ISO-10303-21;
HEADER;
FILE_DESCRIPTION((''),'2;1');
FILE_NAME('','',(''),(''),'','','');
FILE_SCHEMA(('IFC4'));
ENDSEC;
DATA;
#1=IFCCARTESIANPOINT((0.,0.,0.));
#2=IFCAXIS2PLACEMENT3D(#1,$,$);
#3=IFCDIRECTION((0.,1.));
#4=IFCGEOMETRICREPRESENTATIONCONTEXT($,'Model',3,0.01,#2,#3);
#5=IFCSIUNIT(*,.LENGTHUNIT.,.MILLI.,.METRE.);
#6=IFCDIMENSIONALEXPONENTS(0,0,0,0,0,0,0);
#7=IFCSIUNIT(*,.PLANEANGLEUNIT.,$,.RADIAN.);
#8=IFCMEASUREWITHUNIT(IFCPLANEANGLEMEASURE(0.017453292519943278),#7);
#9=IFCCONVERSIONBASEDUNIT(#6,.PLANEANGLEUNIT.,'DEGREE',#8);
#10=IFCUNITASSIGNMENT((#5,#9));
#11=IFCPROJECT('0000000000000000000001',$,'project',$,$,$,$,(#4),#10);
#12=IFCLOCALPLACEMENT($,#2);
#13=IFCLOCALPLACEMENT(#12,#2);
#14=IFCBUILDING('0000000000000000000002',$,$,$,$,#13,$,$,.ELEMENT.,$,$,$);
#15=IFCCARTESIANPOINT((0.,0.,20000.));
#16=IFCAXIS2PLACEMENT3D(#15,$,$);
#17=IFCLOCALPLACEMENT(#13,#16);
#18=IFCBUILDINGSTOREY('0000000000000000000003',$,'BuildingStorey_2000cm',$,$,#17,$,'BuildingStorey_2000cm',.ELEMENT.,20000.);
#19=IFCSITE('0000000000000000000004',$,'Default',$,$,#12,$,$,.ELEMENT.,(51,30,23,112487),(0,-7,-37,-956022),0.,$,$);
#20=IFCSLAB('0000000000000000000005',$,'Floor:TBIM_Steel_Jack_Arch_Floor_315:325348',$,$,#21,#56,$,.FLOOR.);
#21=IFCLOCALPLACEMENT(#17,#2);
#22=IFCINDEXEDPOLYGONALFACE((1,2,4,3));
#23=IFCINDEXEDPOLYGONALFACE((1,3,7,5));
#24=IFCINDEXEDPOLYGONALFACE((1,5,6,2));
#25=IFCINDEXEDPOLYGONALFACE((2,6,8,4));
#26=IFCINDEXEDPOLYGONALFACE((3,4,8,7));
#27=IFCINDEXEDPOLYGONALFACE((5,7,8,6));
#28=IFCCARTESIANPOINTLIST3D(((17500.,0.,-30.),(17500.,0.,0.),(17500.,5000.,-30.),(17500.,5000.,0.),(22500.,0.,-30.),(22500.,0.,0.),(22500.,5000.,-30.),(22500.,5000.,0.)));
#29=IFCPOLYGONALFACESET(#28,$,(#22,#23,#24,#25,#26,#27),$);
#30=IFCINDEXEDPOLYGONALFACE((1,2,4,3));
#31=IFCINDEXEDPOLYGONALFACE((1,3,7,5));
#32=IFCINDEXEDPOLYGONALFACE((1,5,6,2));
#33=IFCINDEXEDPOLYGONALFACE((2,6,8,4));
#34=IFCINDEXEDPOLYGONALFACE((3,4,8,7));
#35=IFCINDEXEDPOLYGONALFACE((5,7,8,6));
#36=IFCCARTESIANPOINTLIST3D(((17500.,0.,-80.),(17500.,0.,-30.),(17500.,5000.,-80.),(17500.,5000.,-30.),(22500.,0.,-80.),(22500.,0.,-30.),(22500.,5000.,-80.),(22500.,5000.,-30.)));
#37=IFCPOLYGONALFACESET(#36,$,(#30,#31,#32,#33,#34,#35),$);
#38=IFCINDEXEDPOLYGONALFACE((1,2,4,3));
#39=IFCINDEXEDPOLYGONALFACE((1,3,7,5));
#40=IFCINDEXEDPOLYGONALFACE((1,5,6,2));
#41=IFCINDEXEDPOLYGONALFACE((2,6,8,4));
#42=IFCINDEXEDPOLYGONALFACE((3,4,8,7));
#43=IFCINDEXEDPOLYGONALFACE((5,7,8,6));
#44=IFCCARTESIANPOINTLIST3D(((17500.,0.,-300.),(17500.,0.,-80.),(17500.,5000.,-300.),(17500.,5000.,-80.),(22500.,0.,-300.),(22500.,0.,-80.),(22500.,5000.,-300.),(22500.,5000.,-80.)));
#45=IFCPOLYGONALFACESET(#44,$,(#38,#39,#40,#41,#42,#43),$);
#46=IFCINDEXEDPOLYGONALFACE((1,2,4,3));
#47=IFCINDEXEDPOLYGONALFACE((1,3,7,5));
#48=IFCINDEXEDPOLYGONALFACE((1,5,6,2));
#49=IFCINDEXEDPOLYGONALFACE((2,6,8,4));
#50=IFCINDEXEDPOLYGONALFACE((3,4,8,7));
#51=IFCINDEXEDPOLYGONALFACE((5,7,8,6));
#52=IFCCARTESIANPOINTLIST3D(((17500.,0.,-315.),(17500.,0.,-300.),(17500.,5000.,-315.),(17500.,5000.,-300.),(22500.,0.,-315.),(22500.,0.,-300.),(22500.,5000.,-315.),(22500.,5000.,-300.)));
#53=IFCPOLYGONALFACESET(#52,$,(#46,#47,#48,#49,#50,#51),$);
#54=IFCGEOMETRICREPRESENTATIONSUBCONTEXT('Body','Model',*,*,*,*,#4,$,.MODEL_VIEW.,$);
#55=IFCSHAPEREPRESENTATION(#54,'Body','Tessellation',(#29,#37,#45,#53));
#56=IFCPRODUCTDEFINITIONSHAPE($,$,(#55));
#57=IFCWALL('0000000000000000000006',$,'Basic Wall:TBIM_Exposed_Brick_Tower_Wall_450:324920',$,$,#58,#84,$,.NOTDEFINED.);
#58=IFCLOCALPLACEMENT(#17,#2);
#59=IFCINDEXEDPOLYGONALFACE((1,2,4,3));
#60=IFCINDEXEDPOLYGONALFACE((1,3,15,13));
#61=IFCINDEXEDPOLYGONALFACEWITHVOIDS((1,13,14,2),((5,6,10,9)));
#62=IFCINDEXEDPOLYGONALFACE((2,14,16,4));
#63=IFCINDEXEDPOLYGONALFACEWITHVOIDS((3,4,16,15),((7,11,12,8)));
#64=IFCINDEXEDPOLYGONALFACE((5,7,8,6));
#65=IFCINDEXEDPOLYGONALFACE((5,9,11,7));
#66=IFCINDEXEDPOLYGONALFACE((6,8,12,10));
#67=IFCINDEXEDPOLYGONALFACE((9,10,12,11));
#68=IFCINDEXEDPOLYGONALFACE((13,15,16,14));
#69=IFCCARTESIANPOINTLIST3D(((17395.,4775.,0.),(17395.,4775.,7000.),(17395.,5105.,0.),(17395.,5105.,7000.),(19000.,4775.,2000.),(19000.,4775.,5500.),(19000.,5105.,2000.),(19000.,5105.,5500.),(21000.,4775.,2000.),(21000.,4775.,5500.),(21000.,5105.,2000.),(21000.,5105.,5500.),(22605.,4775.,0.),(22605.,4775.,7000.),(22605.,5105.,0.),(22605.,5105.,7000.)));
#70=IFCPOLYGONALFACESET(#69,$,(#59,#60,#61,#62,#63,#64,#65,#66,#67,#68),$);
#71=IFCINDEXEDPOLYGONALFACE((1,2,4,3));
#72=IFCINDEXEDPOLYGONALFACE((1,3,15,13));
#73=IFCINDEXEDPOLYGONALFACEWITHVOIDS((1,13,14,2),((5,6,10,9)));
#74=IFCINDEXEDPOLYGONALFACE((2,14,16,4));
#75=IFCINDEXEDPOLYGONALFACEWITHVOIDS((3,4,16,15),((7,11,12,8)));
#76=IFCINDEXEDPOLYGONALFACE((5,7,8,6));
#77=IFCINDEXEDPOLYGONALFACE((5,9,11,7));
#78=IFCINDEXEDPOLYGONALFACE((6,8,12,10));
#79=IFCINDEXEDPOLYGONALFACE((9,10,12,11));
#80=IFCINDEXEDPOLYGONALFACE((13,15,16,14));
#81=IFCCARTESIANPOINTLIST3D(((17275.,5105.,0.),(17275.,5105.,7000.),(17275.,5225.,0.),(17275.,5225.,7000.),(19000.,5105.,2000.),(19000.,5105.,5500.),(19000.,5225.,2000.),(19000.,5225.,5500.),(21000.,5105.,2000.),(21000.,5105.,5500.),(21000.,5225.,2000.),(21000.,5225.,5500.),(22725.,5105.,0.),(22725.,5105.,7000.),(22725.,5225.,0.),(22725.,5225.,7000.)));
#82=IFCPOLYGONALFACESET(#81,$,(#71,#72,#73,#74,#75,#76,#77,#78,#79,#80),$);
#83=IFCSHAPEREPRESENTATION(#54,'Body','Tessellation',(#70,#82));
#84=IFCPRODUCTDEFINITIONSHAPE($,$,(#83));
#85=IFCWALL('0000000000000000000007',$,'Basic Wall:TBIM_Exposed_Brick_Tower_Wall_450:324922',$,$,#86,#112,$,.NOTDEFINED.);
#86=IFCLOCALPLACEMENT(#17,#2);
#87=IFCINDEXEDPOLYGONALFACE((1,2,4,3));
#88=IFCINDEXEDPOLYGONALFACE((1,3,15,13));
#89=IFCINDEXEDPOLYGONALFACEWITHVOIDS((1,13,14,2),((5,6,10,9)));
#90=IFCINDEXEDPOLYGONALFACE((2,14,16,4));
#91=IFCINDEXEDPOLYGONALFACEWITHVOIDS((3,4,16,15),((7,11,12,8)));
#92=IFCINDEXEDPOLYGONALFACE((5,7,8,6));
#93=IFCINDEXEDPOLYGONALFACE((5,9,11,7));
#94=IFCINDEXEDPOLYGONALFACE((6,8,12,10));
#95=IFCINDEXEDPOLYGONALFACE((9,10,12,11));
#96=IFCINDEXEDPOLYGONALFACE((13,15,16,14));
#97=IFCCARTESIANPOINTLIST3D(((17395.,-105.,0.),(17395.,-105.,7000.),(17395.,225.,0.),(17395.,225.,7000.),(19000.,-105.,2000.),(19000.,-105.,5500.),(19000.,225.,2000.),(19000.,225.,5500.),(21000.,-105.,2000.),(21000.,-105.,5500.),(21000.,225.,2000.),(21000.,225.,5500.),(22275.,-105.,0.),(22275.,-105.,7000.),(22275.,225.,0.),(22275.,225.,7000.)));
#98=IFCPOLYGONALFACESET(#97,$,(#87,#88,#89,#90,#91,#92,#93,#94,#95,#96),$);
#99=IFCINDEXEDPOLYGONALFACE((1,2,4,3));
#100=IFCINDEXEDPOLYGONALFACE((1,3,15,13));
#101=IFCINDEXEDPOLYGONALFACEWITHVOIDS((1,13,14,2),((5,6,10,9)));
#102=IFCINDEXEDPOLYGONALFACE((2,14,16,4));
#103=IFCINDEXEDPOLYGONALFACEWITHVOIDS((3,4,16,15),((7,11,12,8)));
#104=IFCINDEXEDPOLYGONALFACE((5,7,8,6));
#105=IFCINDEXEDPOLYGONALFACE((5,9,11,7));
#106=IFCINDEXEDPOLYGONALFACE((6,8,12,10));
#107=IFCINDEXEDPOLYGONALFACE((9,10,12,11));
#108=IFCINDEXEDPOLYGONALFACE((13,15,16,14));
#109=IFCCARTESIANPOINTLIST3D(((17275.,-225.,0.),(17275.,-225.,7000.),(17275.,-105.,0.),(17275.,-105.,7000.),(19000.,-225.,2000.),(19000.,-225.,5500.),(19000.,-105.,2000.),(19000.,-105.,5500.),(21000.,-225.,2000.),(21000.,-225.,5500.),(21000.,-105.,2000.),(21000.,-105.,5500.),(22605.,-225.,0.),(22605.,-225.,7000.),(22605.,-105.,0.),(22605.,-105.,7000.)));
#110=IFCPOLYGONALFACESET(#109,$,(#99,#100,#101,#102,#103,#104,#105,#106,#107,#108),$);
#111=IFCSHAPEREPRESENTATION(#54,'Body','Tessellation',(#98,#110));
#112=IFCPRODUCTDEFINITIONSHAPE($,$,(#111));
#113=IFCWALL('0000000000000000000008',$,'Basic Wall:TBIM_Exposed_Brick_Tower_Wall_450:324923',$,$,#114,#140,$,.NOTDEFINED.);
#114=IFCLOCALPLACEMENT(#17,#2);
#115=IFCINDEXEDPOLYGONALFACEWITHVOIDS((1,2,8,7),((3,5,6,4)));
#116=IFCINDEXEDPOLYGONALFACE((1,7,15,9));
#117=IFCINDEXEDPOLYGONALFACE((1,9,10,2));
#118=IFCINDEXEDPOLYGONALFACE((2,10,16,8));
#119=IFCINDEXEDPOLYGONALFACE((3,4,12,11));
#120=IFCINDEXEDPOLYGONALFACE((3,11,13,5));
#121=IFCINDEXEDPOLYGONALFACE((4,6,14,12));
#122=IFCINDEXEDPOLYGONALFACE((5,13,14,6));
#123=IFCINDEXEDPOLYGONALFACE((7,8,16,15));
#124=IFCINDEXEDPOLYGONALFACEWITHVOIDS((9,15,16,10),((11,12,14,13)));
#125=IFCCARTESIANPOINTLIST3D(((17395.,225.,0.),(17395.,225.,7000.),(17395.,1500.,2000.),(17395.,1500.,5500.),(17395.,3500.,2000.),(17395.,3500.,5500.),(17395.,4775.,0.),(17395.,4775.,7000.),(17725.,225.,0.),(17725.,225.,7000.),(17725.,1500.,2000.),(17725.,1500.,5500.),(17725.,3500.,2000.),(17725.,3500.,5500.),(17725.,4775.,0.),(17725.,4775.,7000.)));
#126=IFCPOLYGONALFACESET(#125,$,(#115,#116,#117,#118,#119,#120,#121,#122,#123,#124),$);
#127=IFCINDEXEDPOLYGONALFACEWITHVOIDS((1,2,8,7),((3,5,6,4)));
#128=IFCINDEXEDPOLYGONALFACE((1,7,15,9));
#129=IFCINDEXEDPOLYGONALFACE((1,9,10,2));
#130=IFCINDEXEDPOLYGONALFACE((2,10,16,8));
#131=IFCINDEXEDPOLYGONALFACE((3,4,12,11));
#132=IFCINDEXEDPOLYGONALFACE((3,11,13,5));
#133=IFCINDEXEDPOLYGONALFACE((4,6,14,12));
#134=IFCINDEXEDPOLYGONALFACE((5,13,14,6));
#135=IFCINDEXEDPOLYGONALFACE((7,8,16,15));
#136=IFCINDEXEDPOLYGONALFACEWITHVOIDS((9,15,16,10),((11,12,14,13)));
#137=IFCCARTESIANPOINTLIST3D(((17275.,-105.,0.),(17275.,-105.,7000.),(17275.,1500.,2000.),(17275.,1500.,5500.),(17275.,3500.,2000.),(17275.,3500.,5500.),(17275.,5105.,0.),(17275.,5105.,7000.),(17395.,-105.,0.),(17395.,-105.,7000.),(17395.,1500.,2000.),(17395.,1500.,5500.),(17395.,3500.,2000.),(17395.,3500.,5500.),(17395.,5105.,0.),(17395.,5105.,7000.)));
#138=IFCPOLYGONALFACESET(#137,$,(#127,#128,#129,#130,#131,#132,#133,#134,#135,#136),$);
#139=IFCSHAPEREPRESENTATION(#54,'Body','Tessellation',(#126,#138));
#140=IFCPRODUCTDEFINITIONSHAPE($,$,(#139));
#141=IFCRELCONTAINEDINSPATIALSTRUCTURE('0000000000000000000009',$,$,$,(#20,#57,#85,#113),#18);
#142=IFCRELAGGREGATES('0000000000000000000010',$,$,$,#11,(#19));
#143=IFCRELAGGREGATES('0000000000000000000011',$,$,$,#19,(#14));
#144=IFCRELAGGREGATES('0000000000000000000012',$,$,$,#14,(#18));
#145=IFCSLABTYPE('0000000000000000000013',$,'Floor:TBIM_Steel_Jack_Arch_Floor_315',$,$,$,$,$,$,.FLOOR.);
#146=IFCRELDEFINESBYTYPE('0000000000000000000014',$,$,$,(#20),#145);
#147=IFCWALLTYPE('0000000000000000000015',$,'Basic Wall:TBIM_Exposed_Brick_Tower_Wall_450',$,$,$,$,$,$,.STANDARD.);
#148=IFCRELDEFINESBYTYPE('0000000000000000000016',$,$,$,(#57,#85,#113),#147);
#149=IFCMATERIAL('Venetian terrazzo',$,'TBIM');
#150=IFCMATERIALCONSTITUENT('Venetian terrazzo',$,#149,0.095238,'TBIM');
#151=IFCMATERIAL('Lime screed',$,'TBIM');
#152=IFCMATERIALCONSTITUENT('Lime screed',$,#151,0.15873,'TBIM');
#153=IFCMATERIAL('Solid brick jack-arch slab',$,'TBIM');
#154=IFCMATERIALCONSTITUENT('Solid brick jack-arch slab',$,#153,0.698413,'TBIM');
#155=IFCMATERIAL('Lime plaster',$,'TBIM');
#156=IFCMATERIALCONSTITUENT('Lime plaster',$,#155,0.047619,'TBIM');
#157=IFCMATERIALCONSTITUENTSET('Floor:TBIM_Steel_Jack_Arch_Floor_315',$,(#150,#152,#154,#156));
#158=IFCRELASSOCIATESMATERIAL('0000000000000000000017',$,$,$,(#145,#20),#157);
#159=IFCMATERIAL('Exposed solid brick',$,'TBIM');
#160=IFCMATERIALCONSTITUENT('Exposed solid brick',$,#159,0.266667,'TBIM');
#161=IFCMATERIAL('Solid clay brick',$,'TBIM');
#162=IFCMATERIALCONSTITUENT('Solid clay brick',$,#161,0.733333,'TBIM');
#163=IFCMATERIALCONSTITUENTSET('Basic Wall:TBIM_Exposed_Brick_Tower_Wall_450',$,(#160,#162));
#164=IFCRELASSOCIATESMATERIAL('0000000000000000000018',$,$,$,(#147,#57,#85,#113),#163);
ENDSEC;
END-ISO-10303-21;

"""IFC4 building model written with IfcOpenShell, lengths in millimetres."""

from ifc_helpers import new_model, entity, si_unit, converted_unit, direction, frame, origin, place, context, subcontext, project, spatial, indexed_curve, outline, extrude, material, constituent, constituent_set, type_object, element, save


model = new_model("IFC4")

# Units and contexts
model_context = context("Model", 3, precision=0.01, world=origin(), true_north=direction((0.0, 1.0)))
body_context = subcontext(model_context, "Body", "Model", "MODEL_VIEW")
ifc_project = project(units=[si_unit("LENGTHUNIT", "METRE", prefix="MILLI"), converted_unit("PLANEANGLEUNIT", "DEGREE", entity("IfcPlaneAngleMeasure", 0.017453292519943278), si_unit("PLANEANGLEUNIT", "RADIAN"), dimensions=[0, 0, 0, 0, 0, 0, 0])], contexts=[model_context])

# Site, building, storey
site_placement = place(None, origin())
site = spatial("IfcSite", under=ifc_project, at=site_placement, Name="Default", CompositionType="ELEMENT", RefLatitude=(51, 30, 23, 112487), RefLongitude=(0, -7, -37, -956022), RefElevation=0.0)
building_placement = place(site_placement, origin())
building = spatial("IfcBuilding", under=site, at=building_placement, CompositionType="ELEMENT")
storey_placement = place(building_placement, frame((0.0, 0.0, 20000.0)))
storey = spatial("IfcBuildingStorey", under=building, at=storey_placement, Name="BuildingStorey_2000cm", LongName="BuildingStorey_2000cm", CompositionType="ELEMENT", Elevation=20000.0)

# Slab
ifc_material_1 = material(Name="Venetian terrazzo", Category="TBIM")
ifc_constituent_1 = constituent(ifc_material_1, Name="Venetian terrazzo", Category="TBIM", fraction=0.095238)
ifc_material_2 = material(Name="Lime screed", Category="TBIM")
ifc_constituent_2 = constituent(ifc_material_2, Name="Lime screed", Category="TBIM", fraction=0.15873)
ifc_material_3 = material(Name="Solid brick jack-arch slab", Category="TBIM")
ifc_constituent_3 = constituent(ifc_material_3, Name="Solid brick jack-arch slab", Category="TBIM", fraction=0.698413)
ifc_material_4 = material(Name="Lime plaster", Category="TBIM")
ifc_constituent_4 = constituent(ifc_material_4, Name="Lime plaster", Category="TBIM", fraction=0.047619)
ifc_constituent_set_1 = constituent_set(constituents=[ifc_constituent_1, ifc_constituent_2, ifc_constituent_3, ifc_constituent_4], Name="Floor:TBIM_Steel_Jack_Arch_Floor_315")
slab_type = type_object("IfcSlabType", Name="Floor:TBIM_Steel_Jack_Arch_Floor_315", PredefinedType="FLOOR", material=ifc_constituent_set_1)
slab_placement = place(storey_placement, origin())
element("IfcSlab", 1, at=slab_placement, inside=storey, type_object=slab_type, material=ifc_constituent_set_1, Name="Floor:TBIM_Steel_Jack_Arch_Floor_315:325348", PredefinedType="FLOOR", context=body_context, shape_type="SweptSolid", body=[
    extrude(outline(indexed_curve([(-2500.0, -2500.0), (2500.0, -2500.0), (2500.0, 2500.0), (-2500.0, 2500.0), (-2500.0, -2500.0)], self_intersect=False)), frame((20000.0, 2500.0, -30.0), z_axis=(0.0, 0.0, 1.0), x_axis=(-1.0, 0.0, 0.0)), (0.0, 0.0, 1.0), 30.0),
    extrude(outline(indexed_curve([(-2500.0, -2500.0), (2500.0, -2500.0), (2500.0, 2500.0), (-2500.0, 2500.0), (-2500.0, -2500.0)], self_intersect=False)), frame((20000.0, 2500.0, -80.0), z_axis=(0.0, 0.0, 1.0), x_axis=(-1.0, 0.0, 0.0)), (0.0, 0.0, 1.0), 50.0),
    extrude(outline(indexed_curve([(-2500.0, -2500.0), (2500.0, -2500.0), (2500.0, 2500.0), (-2500.0, 2500.0), (-2500.0, -2500.0)], self_intersect=False)), frame((20000.0, 2500.0, -300.0), z_axis=(0.0, 0.0, 1.0), x_axis=(-1.0, 0.0, 0.0)), (0.0, 0.0, 1.0), 220.0),
    extrude(outline(indexed_curve([(-2500.0, -2500.0), (2500.0, -2500.0), (2500.0, 2500.0), (-2500.0, 2500.0), (-2500.0, -2500.0)], self_intersect=False)), frame((20000.0, 2500.0, -315.0), z_axis=(0.0, 0.0, 1.0), x_axis=(-1.0, 0.0, 0.0)), (0.0, 0.0, 1.0), 15.0),
])

# Walls, openings
ifc_material_5 = material(Name="Exposed solid brick", Category="TBIM")
ifc_constituent_5 = constituent(ifc_material_5, Name="Exposed solid brick", Category="TBIM", fraction=0.266667)
ifc_material_6 = material(Name="Solid clay brick", Category="TBIM")
ifc_constituent_6 = constituent(ifc_material_6, Name="Solid clay brick", Category="TBIM", fraction=0.733333)
ifc_constituent_set_2 = constituent_set(constituents=[ifc_constituent_5, ifc_constituent_6], Name="Basic Wall:TBIM_Exposed_Brick_Tower_Wall_450")
wall_type = type_object("IfcWallType", Name="Basic Wall:TBIM_Exposed_Brick_Tower_Wall_450", PredefinedType="STANDARD", material=ifc_constituent_set_2)
wall_1_placement = place(storey_placement, frame((22725.0, 5000.0, 0.0), z_axis=(0.0, 0.0, 1.0), x_axis=(-1.0, 0.0, 0.0)))
wall_1 = element("IfcWall", 2, at=wall_1_placement, inside=storey, type_object=wall_type, material=ifc_constituent_set_2, Name="Basic Wall:TBIM_Exposed_Brick_Tower_Wall_450:324920", PredefinedType="NOTDEFINED", context=body_context, shape_type="SweptSolid", body=[
    extrude(outline(indexed_curve([(-2605.0, -3500.0), (-2275.0, -3500.0), (2275.0, -3500.0), (2605.0, -3500.0), (2605.0, 3500.0), (2275.0, 3500.0), (-2275.0, 3500.0), (-2605.0, 3500.0), (-2605.0, -3500.0)], self_intersect=False), holes=[indexed_curve([(-1000.0, 2000.0), (1000.0, 2000.0), (1000.0, -1500.0), (-1000.0, -1500.0), (-1000.0, 2000.0)], self_intersect=False)]), frame((2725.0, 225.0, 3500.0), z_axis=(0.0, -1.0, 0.0), x_axis=(1.0, 0.0, 0.0)), (0.0, 0.0, 1.0), 330.0),
    extrude(outline(indexed_curve([(-3500.0, -2725.0), (3500.0, -2725.0), (3500.0, 2725.0), (-3500.0, 2725.0), (-3500.0, -2725.0)], self_intersect=False), holes=[indexed_curve([(2000.0, 1000.0), (2000.0, -1000.0), (-1500.0, -1000.0), (-1500.0, 1000.0), (2000.0, 1000.0)], self_intersect=False)]), frame((2725.0, -105.0, 3500.0), z_axis=(0.0, -1.0, 0.0), x_axis=(0.0, 0.0, 1.0)), (0.0, 0.0, 1.0), 120.0),
])
opening_1_placement = place(wall_1_placement, frame((1725.0, -225.0, 2000.0)))
element("IfcOpeningElement", 3, at=opening_1_placement, cuts=wall_1, PredefinedType="OPENING", context=body_context, shape_type="SweptSolid", body=[
    extrude(outline(indexed_curve([(3500.0, 0.0), (3500.0, 2000.0), (0.0, 2000.0), (0.0, 0.0), (3500.0, 0.0)], self_intersect=False)), frame((0.0, 0.0, 0.0), z_axis=(0.0, 1.0, 0.0), x_axis=(0.0, 0.0, 1.0)), (0.0, 0.0, 1.0), 450.0),
])
wall_2_placement = place(storey_placement, frame((22275.0, 0.0, 0.0), z_axis=(0.0, 0.0, 1.0), x_axis=(-1.0, 0.0, 0.0)))
wall_2 = element("IfcWall", 4, at=wall_2_placement, inside=storey, type_object=wall_type, material=ifc_constituent_set_2, Name="Basic Wall:TBIM_Exposed_Brick_Tower_Wall_450:324922", PredefinedType="NOTDEFINED", context=body_context, shape_type="SweptSolid", body=[
    extrude(outline(indexed_curve([(-3500.0, -2440.0), (3500.0, -2440.0), (3500.0, 2440.0), (-3500.0, 2440.0), (-3500.0, -2440.0)], self_intersect=False), holes=[indexed_curve([(2000.0, 1165.0), (2000.0, -835.0), (-1500.0, -835.0), (-1500.0, 1165.0), (2000.0, 1165.0)], self_intersect=False)]), frame((2440.0, 105.0, 3500.0), z_axis=(0.0, -1.0, 0.0), x_axis=(0.0, 0.0, 1.0)), (0.0, 0.0, 1.0), 330.0),
    extrude(outline(indexed_curve([(-2665.0, -3500.0), (2665.0, -3500.0), (2665.0, 3500.0), (-2665.0, 3500.0), (-2665.0, -3500.0)], self_intersect=False), holes=[indexed_curve([(-1060.0, 2000.0), (940.0, 2000.0), (940.0, -1500.0), (-1060.0, -1500.0), (-1060.0, 2000.0)], self_intersect=False)]), frame((2335.0, 225.0, 3500.0), z_axis=(0.0, -1.0, 0.0), x_axis=(1.0, 0.0, 0.0)), (0.0, 0.0, 1.0), 120.0),
])
opening_2_placement = place(wall_2_placement, frame((1275.0, -225.0, 2000.0)))
element("IfcOpeningElement", 5, at=opening_2_placement, cuts=wall_2, PredefinedType="OPENING", context=body_context, shape_type="SweptSolid", body=[
    extrude(outline(indexed_curve([(3500.0, 0.0), (3500.0, 2000.0), (0.0, 2000.0), (0.0, 0.0), (3500.0, 0.0)], self_intersect=False)), frame((0.0, 0.0, 0.0), z_axis=(0.0, 1.0, 0.0), x_axis=(0.0, 0.0, 1.0)), (0.0, 0.0, 1.0), 450.0),
])
wall_3_placement = place(storey_placement, frame((17500.0, 4775.0, 0.0), z_axis=(0.0, 0.0, 1.0), x_axis=(0.0, -1.0, 0.0)))
wall_3 = element("IfcWall", 6, at=wall_3_placement, inside=storey, type_object=wall_type, material=ifc_constituent_set_2, Name="Basic Wall:TBIM_Exposed_Brick_Tower_Wall_450:324923", PredefinedType="NOTDEFINED", context=body_context, shape_type="SweptSolid", body=[
    extrude(outline(indexed_curve([(-3500.0, -2275.0), (3500.0, -2275.0), (3500.0, 2275.0), (-3500.0, 2275.0), (-3500.0, -2275.0)], self_intersect=False), holes=[indexed_curve([(-1500.0, -1000.0), (-1500.0, 1000.0), (2000.0, 1000.0), (2000.0, -1000.0), (-1500.0, -1000.0)], self_intersect=False)]), frame((2275.0, -105.0, 3500.0), z_axis=(0.0, 1.0, 0.0), x_axis=(0.0, 0.0, 1.0)), (0.0, 0.0, 1.0), 330.0),
    extrude(outline(indexed_curve([(-3500.0, -2605.0), (3500.0, -2605.0), (3500.0, 2605.0), (-3500.0, 2605.0), (-3500.0, -2605.0)], self_intersect=False), holes=[indexed_curve([(2000.0, -1000.0), (-1500.0, -1000.0), (-1500.0, 1000.0), (2000.0, 1000.0), (2000.0, -1000.0)], self_intersect=False)]), frame((2275.0, -225.0, 3500.0), z_axis=(0.0, 1.0, 0.0), x_axis=(0.0, 0.0, 1.0)), (0.0, 0.0, 1.0), 120.0),
])
opening_3_placement = place(wall_3_placement, frame((1275.0, -225.0, 2000.0)))
element("IfcOpeningElement", 7, at=opening_3_placement, cuts=wall_3, PredefinedType="OPENING", context=body_context, shape_type="SweptSolid", body=[
    extrude(outline(indexed_curve([(3500.0, 0.0), (3500.0, 2000.0), (0.0, 2000.0), (0.0, 0.0), (3500.0, 0.0)], self_intersect=False)), frame((0.0, 0.0, 0.0), z_axis=(0.0, 1.0, 0.0), x_axis=(0.0, 0.0, 1.0)), (0.0, 0.0, 1.0), 450.0),
])

save(model, "model.ifc")
